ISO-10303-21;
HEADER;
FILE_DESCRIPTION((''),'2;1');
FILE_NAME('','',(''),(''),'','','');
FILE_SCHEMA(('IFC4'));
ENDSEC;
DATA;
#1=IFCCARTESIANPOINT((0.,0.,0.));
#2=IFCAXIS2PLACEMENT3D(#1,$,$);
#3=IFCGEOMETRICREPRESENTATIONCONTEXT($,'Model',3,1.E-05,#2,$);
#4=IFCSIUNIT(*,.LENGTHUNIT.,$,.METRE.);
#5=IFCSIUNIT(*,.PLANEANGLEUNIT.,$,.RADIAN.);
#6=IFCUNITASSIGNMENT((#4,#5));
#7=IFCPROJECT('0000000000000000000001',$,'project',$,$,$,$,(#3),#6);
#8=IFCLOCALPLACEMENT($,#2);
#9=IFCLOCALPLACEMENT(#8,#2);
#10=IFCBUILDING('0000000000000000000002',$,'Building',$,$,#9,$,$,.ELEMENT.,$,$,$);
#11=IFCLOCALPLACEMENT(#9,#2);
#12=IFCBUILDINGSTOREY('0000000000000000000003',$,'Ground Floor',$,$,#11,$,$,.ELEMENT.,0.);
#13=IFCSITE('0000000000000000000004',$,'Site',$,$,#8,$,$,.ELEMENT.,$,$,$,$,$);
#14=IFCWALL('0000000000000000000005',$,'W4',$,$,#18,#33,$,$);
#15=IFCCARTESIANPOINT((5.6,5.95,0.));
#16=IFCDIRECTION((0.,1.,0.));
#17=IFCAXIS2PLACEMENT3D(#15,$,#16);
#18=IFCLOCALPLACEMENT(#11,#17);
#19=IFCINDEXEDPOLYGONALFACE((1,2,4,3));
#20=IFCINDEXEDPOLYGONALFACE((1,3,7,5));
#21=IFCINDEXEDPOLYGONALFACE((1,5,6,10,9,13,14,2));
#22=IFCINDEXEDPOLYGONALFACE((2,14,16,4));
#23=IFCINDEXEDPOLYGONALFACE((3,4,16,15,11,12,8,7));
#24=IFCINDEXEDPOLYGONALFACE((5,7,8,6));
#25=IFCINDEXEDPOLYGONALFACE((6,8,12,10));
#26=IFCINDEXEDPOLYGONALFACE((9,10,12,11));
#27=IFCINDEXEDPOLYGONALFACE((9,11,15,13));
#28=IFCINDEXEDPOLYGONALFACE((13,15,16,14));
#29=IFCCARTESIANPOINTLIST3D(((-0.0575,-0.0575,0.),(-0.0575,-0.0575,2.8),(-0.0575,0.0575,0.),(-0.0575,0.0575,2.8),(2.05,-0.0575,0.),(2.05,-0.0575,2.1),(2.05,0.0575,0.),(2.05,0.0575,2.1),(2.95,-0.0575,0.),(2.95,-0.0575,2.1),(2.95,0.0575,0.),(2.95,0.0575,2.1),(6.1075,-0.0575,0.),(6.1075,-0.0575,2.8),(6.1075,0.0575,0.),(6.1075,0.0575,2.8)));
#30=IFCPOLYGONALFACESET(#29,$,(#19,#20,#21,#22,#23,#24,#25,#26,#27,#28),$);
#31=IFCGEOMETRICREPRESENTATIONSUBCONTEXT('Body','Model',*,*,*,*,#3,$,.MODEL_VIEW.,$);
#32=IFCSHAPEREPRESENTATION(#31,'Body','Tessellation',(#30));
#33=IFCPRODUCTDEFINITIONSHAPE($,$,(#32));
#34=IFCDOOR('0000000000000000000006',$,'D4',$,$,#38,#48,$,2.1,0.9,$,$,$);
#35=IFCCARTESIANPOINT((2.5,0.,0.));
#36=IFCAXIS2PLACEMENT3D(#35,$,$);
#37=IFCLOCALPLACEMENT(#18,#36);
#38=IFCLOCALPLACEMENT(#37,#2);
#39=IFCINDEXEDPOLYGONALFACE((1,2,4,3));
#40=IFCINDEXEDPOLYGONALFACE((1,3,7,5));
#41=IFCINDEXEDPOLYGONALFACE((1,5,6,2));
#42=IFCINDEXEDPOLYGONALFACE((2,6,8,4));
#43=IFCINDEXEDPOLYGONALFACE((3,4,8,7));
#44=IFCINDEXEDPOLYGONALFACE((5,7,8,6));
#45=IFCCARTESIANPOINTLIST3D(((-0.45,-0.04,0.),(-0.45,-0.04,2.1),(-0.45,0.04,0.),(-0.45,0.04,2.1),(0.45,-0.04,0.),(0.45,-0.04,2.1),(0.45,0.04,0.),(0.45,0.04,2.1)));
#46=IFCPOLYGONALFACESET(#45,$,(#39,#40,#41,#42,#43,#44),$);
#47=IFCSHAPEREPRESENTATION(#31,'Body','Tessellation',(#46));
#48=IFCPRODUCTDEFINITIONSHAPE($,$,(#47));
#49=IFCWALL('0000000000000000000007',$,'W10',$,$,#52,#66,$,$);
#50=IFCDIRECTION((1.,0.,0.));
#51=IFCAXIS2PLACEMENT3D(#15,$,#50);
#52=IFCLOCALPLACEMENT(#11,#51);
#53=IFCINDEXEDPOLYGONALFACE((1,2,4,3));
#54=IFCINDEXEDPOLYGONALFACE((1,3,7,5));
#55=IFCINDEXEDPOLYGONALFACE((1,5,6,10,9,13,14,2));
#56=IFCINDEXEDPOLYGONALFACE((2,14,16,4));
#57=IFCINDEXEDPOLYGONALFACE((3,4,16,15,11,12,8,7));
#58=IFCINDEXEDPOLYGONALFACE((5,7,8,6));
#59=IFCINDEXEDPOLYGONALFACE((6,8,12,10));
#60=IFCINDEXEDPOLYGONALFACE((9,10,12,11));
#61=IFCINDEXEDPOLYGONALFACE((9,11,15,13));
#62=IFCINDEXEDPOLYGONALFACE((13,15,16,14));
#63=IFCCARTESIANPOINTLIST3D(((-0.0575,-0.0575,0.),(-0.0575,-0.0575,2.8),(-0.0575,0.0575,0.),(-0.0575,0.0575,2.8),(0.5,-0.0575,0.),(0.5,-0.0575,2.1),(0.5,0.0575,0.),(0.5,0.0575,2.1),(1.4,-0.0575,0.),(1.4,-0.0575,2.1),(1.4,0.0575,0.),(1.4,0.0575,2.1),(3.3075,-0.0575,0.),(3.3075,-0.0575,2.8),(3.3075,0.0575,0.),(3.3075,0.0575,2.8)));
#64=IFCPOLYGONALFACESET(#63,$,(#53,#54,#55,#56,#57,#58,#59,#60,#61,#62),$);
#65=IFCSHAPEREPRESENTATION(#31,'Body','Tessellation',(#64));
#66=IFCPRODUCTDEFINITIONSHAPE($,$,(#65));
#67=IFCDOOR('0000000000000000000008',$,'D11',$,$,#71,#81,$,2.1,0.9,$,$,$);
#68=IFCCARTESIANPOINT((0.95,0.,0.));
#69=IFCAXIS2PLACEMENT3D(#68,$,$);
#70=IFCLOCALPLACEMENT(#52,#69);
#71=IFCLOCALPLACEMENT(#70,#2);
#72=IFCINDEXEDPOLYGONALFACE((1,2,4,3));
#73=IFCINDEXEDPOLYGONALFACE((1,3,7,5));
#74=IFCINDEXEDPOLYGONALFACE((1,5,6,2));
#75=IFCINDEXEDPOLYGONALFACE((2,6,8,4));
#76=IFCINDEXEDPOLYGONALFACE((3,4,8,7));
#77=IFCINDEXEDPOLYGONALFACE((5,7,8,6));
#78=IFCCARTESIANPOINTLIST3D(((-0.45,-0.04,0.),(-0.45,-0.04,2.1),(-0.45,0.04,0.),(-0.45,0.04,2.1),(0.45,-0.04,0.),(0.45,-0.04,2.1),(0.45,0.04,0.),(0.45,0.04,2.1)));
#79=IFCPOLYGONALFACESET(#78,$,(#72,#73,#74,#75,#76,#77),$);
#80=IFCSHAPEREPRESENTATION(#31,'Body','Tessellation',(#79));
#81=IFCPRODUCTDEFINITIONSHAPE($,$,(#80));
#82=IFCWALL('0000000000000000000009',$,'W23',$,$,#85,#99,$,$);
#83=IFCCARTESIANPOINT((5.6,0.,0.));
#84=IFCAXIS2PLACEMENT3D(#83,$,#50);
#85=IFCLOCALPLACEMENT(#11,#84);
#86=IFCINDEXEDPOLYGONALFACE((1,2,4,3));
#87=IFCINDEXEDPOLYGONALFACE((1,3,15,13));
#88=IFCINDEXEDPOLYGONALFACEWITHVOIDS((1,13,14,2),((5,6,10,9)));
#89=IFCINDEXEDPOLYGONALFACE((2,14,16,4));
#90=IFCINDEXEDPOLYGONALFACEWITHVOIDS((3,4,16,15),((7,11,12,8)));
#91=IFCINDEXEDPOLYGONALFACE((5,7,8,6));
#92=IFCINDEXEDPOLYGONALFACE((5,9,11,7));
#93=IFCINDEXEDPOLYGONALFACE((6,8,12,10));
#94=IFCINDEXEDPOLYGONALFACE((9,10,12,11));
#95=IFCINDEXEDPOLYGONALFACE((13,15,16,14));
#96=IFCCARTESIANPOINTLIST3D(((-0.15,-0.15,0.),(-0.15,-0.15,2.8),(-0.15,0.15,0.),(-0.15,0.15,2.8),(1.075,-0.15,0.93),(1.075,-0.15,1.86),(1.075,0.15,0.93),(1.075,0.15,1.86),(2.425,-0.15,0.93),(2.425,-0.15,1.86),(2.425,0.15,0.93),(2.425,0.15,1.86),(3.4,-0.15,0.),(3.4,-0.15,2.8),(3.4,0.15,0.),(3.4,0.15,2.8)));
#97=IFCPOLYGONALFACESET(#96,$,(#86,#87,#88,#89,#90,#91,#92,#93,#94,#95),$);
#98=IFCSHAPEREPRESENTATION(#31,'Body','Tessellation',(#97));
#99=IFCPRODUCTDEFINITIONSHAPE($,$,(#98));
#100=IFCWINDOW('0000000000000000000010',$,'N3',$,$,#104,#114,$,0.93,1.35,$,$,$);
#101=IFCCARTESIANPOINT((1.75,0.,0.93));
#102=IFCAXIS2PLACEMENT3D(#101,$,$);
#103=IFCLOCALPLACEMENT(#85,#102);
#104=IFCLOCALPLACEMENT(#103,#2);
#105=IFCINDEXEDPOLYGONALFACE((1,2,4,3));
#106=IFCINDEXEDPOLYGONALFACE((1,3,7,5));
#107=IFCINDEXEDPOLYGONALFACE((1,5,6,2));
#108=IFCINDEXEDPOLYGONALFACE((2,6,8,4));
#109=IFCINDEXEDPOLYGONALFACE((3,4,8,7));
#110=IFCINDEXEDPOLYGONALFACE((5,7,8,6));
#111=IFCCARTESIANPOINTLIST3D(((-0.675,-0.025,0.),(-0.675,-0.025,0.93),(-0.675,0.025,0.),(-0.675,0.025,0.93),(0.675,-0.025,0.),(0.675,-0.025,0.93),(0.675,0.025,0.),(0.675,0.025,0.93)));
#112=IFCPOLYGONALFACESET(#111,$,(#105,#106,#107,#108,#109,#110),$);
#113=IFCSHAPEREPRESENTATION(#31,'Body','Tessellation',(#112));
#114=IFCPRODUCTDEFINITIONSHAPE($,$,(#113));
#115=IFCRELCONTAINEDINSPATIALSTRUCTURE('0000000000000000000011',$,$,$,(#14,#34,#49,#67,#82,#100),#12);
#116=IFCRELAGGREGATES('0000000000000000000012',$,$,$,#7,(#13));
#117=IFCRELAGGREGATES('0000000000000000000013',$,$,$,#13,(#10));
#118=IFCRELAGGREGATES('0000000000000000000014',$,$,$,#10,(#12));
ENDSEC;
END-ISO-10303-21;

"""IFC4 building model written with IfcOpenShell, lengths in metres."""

from ifc_helpers import new_model, si_unit, frame, frame_2d, origin, origin_2d, place, context, subcontext, project, spatial, rectangle, extrude, element, fill, save


model = new_model("IFC4")

# Units and contexts
model_context = context("Model", 3, precision=1e-05, world=origin())
body_context = subcontext(model_context, "Body", "Model", "MODEL_VIEW")
ifc_project = project(units=[si_unit("LENGTHUNIT", "METRE"), si_unit("PLANEANGLEUNIT", "RADIAN")], contexts=[model_context])

# Site, building, storey
site_placement = place(None, origin())
site = spatial("IfcSite", under=ifc_project, at=site_placement, Name="Site", CompositionType="ELEMENT")
building_placement = place(site_placement, origin())
building = spatial("IfcBuilding", under=site, at=building_placement, Name="Building", CompositionType="ELEMENT")
storey_placement = place(building_placement, origin())
storey = spatial("IfcBuildingStorey", under=building, at=storey_placement, Name="Ground Floor", CompositionType="ELEMENT", Elevation=0.0)

# Walls, openings, doors
wall_1_placement = place(storey_placement, frame((5.6, 5.95, 0.0), x_axis=(0.0, 1.0, 0.0)))
wall_1 = element("IfcWall", 1, at=wall_1_placement, inside=storey, Name="W4", context=body_context, shape_type="SweptSolid", body=[
    extrude(rectangle(XDim=6.165, YDim=0.115, at=frame_2d((3.025, 0.0))), origin(), (0.0, 0.0, 1.0), 2.8),
])
opening_1_placement = place(wall_1_placement, frame((2.5, 0.0, 0.0)))
opening_1 = element("IfcOpeningElement", 2, at=opening_1_placement, cuts=wall_1, context=body_context, shape_type="SweptSolid", body=[
    extrude(rectangle(XDim=0.9, YDim=0.215, at=origin_2d()), origin(), (0.0, 0.0, 1.0), 2.1),
])
door_1_placement = place(opening_1_placement, origin())
door_1 = element("IfcDoor", 3, at=door_1_placement, inside=storey, Name="D4", OverallHeight=2.1, OverallWidth=0.9, context=body_context, shape_type="SweptSolid", body=[
    extrude(rectangle(XDim=0.9, YDim=0.08, at=origin_2d()), origin(), (0.0, 0.0, 1.0), 2.1),
])
fill(opening_1, door_1)
wall_2_placement = place(storey_placement, frame((5.6, 5.95, 0.0), x_axis=(1.0, 0.0, 0.0)))
wall_2 = element("IfcWall", 4, at=wall_2_placement, inside=storey, Name="W10", context=body_context, shape_type="SweptSolid", body=[
    extrude(rectangle(XDim=3.365, YDim=0.115, at=frame_2d((1.625, 0.0))), origin(), (0.0, 0.0, 1.0), 2.8),
])
opening_2_placement = place(wall_2_placement, frame((0.95, 0.0, 0.0)))
opening_2 = element("IfcOpeningElement", 5, at=opening_2_placement, cuts=wall_2, context=body_context, shape_type="SweptSolid", body=[
    extrude(rectangle(XDim=0.9, YDim=0.215, at=origin_2d()), origin(), (0.0, 0.0, 1.0), 2.1),
])
door_2_placement = place(opening_2_placement, origin())
door_2 = element("IfcDoor", 6, at=door_2_placement, inside=storey, Name="D11", OverallHeight=2.1, OverallWidth=0.9, context=body_context, shape_type="SweptSolid", body=[
    extrude(rectangle(XDim=0.9, YDim=0.08, at=origin_2d()), origin(), (0.0, 0.0, 1.0), 2.1),
])
fill(opening_2, door_2)

# Wall, opening, window
wall_3_placement = place(storey_placement, frame((5.6, 0.0, 0.0), x_axis=(1.0, 0.0, 0.0)))
wall_3 = element("IfcWall", 7, at=wall_3_placement, inside=storey, Name="W23", context=body_context, shape_type="SweptSolid", body=[
    extrude(rectangle(XDim=3.55, YDim=0.3, at=frame_2d((1.625, 0.0))), origin(), (0.0, 0.0, 1.0), 2.8),
])
opening_3_placement = place(wall_3_placement, frame((1.75, 0.0, 0.93)))
opening_3 = element("IfcOpeningElement", 8, at=opening_3_placement, cuts=wall_3, context=body_context, shape_type="SweptSolid", body=[
    extrude(rectangle(XDim=1.35, YDim=0.4, at=origin_2d()), origin(), (0.0, 0.0, 1.0), 0.93),
])
window_1_placement = place(opening_3_placement, origin())
window_1 = element("IfcWindow", 9, at=window_1_placement, inside=storey, Name="N3", OverallHeight=0.93, OverallWidth=1.35, context=body_context, shape_type="SweptSolid", body=[
    extrude(rectangle(XDim=1.35, YDim=0.05, at=origin_2d()), origin(), (0.0, 0.0, 1.0), 0.93),
])
fill(opening_3, window_1)

save(model, "model.ifc")
